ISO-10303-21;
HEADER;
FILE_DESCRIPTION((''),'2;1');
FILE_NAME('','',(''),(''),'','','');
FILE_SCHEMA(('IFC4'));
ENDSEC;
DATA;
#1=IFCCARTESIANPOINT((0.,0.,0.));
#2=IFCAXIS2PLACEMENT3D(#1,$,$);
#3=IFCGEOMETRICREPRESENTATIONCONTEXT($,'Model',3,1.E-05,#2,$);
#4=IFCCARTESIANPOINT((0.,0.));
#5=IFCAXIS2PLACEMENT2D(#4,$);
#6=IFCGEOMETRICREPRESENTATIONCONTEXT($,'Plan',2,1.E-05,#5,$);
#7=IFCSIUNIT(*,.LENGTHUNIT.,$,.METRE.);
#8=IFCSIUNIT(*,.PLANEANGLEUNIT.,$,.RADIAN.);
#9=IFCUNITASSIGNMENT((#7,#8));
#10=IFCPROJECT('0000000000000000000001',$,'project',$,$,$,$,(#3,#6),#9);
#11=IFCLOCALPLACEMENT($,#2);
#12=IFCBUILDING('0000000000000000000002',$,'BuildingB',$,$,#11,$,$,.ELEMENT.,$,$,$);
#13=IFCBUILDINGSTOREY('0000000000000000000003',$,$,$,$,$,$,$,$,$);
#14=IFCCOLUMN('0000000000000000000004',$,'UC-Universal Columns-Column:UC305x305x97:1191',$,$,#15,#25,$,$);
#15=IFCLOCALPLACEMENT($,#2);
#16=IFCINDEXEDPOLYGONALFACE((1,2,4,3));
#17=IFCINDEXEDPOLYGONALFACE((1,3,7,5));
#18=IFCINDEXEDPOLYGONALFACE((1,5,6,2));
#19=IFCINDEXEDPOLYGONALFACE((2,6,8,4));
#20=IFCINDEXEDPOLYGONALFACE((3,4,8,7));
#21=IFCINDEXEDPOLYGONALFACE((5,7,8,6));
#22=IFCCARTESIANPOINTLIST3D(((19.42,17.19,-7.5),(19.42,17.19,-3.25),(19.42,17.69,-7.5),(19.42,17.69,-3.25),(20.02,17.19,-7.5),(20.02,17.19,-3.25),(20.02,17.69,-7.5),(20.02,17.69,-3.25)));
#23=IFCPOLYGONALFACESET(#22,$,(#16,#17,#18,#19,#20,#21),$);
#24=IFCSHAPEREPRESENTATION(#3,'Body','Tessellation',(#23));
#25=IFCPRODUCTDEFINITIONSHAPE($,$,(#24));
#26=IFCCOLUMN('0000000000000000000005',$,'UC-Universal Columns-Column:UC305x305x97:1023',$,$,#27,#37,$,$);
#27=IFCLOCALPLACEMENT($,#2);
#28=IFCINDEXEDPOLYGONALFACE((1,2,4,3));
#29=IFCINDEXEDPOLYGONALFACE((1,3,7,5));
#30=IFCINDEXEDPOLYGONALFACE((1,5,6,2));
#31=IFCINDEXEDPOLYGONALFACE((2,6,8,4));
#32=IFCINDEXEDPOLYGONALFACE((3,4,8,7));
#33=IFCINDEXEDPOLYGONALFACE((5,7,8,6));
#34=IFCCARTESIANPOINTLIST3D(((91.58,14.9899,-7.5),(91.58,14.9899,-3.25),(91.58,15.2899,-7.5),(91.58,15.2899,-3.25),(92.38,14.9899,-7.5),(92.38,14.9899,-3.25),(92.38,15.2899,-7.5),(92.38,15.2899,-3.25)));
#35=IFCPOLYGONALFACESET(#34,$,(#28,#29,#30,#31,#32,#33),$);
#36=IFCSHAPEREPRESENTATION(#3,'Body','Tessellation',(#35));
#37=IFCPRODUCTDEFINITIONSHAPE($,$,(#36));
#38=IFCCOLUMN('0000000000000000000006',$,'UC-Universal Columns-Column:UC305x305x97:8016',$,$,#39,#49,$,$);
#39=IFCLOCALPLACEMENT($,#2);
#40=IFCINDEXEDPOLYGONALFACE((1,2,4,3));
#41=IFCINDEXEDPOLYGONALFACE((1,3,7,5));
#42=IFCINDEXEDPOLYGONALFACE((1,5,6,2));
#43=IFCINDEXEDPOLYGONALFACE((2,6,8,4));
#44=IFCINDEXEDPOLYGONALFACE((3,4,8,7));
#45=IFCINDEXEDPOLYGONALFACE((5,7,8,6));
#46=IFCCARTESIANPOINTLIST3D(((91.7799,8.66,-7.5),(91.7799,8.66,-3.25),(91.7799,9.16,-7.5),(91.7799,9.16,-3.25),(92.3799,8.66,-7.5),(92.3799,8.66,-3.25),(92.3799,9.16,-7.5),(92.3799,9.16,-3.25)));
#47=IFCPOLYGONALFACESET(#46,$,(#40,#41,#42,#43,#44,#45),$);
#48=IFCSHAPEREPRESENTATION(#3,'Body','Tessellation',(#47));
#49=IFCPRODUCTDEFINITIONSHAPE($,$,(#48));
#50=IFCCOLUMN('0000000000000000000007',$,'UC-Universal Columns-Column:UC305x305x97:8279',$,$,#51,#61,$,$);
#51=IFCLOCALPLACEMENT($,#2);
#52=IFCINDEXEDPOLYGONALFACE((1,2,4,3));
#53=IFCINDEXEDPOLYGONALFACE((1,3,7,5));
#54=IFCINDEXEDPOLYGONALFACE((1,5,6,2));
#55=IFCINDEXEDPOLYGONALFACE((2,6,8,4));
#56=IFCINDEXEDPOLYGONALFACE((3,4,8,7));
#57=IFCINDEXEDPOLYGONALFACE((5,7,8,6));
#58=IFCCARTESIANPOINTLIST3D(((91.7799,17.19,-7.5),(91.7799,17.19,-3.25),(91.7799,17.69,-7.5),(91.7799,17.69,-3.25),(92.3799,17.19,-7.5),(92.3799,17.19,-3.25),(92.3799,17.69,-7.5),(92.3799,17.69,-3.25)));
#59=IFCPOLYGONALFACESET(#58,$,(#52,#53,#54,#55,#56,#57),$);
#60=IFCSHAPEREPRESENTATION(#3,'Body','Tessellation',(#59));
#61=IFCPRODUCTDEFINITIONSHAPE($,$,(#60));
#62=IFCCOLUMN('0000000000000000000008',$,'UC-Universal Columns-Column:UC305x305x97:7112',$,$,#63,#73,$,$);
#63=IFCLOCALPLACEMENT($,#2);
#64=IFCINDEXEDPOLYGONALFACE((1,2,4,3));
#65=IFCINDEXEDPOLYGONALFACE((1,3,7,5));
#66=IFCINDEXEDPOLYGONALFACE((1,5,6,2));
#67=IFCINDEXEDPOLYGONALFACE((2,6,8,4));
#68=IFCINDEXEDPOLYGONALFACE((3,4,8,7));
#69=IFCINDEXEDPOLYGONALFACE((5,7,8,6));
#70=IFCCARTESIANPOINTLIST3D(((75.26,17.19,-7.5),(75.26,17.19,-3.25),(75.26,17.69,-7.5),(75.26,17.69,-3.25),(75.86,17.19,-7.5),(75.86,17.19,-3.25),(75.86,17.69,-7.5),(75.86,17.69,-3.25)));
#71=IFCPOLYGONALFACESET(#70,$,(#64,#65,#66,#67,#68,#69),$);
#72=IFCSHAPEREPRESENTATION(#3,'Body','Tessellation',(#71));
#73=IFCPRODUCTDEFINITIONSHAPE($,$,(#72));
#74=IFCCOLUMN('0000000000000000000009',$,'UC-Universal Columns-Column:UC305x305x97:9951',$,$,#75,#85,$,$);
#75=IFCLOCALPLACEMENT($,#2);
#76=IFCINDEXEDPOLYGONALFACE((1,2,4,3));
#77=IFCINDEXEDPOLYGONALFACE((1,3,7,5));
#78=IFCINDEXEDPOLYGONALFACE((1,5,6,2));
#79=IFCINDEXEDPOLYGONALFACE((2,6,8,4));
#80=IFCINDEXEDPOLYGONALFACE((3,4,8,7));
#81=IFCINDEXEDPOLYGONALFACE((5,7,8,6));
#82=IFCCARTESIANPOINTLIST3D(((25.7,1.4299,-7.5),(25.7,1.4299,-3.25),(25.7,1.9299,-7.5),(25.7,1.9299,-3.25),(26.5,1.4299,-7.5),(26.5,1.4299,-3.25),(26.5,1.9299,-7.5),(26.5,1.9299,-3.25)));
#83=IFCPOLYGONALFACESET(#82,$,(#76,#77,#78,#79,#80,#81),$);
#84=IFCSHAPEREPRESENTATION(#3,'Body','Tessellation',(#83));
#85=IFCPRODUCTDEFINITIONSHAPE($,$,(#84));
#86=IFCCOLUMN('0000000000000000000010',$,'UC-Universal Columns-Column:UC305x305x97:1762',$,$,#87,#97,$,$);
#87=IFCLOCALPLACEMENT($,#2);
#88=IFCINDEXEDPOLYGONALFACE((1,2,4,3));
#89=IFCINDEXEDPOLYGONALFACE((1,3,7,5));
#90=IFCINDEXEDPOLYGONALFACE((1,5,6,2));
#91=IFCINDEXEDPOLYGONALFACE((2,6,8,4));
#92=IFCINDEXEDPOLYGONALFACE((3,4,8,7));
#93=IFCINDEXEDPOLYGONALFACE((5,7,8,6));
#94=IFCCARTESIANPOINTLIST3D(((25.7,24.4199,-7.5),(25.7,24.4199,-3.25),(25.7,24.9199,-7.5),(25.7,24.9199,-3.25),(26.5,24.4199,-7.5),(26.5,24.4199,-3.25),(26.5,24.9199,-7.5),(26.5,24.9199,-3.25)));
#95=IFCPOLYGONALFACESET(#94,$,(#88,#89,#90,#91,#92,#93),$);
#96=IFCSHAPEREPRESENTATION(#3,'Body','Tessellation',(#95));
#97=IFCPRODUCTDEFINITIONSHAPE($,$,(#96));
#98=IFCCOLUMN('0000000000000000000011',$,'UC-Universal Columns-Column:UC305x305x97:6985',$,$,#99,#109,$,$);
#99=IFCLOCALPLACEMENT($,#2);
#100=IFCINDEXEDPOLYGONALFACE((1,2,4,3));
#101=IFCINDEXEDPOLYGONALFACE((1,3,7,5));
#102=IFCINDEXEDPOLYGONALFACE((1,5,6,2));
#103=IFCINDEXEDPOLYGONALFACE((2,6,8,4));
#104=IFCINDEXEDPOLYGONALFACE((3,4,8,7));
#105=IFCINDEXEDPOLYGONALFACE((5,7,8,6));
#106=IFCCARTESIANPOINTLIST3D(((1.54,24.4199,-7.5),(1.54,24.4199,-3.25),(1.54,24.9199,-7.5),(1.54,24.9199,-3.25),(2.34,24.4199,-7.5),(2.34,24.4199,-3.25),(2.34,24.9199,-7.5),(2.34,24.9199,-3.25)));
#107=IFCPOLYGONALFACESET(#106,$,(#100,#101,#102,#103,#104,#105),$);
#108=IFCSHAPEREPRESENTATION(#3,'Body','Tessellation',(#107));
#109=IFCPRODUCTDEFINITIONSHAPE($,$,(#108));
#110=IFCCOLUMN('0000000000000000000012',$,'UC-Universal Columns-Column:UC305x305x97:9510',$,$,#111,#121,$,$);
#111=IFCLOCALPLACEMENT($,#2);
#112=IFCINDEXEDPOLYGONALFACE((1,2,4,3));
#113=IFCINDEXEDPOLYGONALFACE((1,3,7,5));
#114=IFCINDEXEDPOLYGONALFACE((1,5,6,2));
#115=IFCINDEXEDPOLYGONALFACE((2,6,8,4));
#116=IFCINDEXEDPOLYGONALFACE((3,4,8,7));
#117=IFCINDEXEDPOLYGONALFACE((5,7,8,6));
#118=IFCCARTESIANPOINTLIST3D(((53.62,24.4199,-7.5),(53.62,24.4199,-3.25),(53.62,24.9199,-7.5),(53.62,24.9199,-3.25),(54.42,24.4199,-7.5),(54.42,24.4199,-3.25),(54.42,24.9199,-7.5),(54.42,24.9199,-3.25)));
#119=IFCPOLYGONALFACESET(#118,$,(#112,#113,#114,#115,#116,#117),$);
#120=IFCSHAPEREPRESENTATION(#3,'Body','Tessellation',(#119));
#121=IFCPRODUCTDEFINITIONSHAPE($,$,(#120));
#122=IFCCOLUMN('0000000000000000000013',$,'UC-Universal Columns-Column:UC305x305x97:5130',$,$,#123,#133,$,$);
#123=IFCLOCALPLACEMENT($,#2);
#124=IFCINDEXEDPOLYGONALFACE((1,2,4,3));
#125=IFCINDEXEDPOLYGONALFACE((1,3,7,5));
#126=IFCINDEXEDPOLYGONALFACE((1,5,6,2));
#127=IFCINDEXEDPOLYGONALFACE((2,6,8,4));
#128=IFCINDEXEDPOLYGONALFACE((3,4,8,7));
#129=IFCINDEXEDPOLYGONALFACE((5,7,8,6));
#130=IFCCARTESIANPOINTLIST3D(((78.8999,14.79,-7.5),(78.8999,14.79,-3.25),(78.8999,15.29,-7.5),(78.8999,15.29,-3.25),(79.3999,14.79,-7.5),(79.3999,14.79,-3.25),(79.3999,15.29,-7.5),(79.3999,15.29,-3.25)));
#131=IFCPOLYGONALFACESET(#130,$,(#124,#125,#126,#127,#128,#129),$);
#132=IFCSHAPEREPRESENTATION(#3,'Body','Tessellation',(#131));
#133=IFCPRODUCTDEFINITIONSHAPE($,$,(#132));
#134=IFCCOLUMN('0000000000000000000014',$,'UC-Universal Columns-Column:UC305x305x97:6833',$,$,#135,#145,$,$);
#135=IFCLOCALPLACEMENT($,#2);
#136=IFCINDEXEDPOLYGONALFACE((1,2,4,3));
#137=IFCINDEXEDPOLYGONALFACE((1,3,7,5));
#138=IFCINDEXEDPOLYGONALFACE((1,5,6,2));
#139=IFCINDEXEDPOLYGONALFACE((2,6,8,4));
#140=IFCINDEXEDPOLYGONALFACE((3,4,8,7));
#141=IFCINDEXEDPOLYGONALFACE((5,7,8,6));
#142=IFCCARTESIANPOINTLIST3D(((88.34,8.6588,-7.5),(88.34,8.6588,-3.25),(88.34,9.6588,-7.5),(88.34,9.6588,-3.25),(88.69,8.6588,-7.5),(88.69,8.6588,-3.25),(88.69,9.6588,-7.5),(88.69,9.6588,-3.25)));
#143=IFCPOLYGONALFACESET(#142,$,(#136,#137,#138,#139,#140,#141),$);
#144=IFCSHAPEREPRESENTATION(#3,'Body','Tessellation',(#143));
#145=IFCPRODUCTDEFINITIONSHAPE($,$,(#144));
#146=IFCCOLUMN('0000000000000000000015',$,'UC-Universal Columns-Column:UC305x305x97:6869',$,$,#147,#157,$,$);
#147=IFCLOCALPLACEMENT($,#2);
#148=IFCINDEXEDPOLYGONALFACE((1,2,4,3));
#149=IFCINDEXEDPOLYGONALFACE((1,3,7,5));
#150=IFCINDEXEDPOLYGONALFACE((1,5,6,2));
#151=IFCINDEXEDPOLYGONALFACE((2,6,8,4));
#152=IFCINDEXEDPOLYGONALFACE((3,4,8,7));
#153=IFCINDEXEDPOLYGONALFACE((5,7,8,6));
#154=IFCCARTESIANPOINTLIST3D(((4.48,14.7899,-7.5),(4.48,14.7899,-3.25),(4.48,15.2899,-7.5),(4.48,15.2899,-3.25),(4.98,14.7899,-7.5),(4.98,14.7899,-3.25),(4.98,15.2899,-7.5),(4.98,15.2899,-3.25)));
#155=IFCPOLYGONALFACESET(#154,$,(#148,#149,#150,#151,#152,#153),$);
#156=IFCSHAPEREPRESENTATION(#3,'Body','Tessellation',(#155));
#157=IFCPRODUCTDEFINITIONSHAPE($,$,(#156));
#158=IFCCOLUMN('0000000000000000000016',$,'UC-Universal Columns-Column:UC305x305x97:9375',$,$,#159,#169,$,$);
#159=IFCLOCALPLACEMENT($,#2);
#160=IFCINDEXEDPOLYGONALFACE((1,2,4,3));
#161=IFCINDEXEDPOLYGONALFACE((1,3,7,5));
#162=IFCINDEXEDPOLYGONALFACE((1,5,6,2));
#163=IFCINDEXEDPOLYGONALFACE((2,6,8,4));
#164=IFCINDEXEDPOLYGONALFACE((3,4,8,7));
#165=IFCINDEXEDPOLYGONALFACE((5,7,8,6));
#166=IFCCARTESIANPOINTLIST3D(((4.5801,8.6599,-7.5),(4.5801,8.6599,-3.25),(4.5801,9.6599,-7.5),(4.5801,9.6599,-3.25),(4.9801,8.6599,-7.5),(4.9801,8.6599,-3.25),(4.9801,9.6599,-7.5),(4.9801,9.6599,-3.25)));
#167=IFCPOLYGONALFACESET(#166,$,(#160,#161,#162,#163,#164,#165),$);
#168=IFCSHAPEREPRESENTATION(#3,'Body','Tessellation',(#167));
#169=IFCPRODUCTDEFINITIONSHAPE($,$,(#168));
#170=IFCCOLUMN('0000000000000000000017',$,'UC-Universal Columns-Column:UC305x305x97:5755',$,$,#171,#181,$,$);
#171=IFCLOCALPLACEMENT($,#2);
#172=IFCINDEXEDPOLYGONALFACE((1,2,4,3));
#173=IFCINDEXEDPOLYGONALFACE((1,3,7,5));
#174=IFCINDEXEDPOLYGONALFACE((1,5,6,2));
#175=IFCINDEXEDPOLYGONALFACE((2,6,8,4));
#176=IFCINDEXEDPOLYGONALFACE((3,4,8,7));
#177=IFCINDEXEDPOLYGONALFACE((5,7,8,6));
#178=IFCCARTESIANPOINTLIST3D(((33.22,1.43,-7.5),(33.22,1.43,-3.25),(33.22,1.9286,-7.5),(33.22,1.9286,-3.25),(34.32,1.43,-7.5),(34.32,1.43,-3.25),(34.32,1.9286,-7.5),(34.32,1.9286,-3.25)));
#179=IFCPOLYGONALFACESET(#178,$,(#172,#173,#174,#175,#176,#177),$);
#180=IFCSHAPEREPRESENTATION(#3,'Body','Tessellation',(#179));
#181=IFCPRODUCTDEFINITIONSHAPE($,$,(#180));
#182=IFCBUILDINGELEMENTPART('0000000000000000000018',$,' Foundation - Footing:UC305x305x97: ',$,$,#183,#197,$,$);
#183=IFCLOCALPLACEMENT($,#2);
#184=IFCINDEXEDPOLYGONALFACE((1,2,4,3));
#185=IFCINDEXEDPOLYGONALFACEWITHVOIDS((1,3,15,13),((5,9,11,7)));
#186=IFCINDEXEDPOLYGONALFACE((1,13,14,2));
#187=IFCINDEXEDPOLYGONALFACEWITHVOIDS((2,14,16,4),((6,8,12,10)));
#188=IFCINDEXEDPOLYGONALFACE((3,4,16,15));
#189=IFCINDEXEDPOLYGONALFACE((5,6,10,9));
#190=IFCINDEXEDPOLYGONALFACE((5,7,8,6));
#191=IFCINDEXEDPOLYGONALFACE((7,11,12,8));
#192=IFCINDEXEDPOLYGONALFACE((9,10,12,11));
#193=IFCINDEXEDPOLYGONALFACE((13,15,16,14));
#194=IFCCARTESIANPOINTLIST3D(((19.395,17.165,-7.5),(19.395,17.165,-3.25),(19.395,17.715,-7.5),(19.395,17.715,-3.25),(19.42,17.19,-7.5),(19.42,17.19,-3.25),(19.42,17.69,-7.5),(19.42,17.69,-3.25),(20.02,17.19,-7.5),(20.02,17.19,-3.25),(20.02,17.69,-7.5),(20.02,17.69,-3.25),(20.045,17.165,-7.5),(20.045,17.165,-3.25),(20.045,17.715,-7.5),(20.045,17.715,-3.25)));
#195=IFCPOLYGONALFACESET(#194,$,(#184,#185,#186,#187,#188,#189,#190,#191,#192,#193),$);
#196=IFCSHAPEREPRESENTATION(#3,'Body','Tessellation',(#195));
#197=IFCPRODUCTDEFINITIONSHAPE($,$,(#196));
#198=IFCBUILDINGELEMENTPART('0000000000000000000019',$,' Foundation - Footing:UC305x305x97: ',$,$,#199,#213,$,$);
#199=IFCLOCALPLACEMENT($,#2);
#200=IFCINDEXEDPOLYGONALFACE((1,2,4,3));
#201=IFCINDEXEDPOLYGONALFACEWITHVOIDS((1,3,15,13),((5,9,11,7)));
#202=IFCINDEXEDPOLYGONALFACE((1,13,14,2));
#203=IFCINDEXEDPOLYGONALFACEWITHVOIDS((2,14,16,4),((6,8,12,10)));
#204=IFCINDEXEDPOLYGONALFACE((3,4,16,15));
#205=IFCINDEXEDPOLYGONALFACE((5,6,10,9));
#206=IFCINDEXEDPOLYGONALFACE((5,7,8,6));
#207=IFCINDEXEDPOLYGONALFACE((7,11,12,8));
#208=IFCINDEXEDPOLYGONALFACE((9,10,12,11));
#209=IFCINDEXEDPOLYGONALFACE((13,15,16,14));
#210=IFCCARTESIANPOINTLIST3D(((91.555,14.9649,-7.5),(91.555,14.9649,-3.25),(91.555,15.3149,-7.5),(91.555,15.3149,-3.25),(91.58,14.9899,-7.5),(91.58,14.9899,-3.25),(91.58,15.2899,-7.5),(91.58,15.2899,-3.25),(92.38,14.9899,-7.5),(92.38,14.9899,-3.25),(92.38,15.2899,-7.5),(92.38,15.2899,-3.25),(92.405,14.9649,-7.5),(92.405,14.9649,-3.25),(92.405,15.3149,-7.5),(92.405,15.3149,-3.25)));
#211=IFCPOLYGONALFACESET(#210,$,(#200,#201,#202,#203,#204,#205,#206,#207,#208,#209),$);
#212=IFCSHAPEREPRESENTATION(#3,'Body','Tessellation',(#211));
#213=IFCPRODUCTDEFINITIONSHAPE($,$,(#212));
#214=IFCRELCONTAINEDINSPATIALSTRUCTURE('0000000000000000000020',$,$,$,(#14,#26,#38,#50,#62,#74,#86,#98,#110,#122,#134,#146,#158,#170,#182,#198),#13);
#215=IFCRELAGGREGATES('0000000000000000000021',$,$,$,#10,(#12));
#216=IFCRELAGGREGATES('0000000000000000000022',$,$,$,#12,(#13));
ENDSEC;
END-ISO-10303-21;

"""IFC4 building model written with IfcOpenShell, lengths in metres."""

from ifc_helpers import new_model, si_unit, origin, origin_2d, place, context, project, spatial, polyline, outline, extrude, element, save


model = new_model("IFC4")

# Units and contexts
model_context = context("Model", 3, precision=1e-05, world=origin())
plan_context = context("Plan", 2, precision=1e-05, world=origin_2d())
ifc_project = project(units=[si_unit("LENGTHUNIT", "METRE"), si_unit("PLANEANGLEUNIT", "RADIAN")], contexts=[model_context, plan_context])

# Building, storey
building_placement = place(None, origin())
building = spatial("IfcBuilding", under=ifc_project, at=building_placement, Name="BuildingB", CompositionType="ELEMENT")
storey = spatial("IfcBuildingStorey", under=building)

# Columns
element("IfcColumn", 1, inside=storey, Name="UC-Universal Columns-Column:UC305x305x97:1191", context=model_context, shape_type="SweptSolid", body=[
    extrude(outline(polyline([(19.42, 17.69, -7.5), (20.02, 17.69, -7.5), (20.02, 17.19, -7.5), (19.42, 17.19, -7.5), (19.42, 17.69, -7.5)])), None, (0.0, 0.0, 1.0), 4.25),
])
element("IfcColumn", 2, inside=storey, Name="UC-Universal Columns-Column:UC305x305x97:1023", context=model_context, shape_type="SweptSolid", body=[
    extrude(outline(polyline([(92.38, 15.2899, -7.5), (91.58, 15.2899, -7.5), (91.58, 14.9899, -7.5), (92.38, 14.9899, -7.5), (92.38, 15.2899, -7.5)])), None, (0.0, 0.0, 1.0), 4.25),
])
element("IfcColumn", 3, inside=storey, Name="UC-Universal Columns-Column:UC305x305x97:8016", context=model_context, shape_type="SweptSolid", body=[
    extrude(outline(polyline([(92.3799, 8.66, -7.5), (91.7799, 8.66, -7.5), (91.7799, 9.16, -7.5), (92.3799, 9.16, -7.5), (92.3799, 8.66, -7.5)])), None, (0.0, 0.0, 1.0), 4.25),
])
element("IfcColumn", 4, inside=storey, Name="UC-Universal Columns-Column:UC305x305x97:8279", context=model_context, shape_type="SweptSolid", body=[
    extrude(outline(polyline([(92.3799, 17.69, -7.5), (91.7799, 17.69, -7.5), (91.7799, 17.19, -7.5), (92.3799, 17.19, -7.5), (92.3799, 17.69, -7.5)])), None, (0.0, 0.0, 1.0), 4.25),
])
element("IfcColumn", 5, inside=storey, Name="UC-Universal Columns-Column:UC305x305x97:7112", context=model_context, shape_type="SweptSolid", body=[
    extrude(outline(polyline([(75.26, 17.69, -7.5), (75.86, 17.69, -7.5), (75.86, 17.19, -7.5), (75.26, 17.19, -7.5), (75.26, 17.69, -7.5)])), None, (0.0, 0.0, 1.0), 4.25),
])
element("IfcColumn", 6, inside=storey, Name="UC-Universal Columns-Column:UC305x305x97:9951", context=model_context, shape_type="SweptSolid", body=[
    extrude(outline(polyline([(25.7, 1.4299, -7.5), (26.5, 1.4299, -7.5), (26.5, 1.9299, -7.5), (25.7, 1.9299, -7.5), (25.7, 1.4299, -7.5)])), None, (0.0, 0.0, 1.0), 4.25),
])
element("IfcColumn", 7, inside=storey, Name="UC-Universal Columns-Column:UC305x305x97:1762", context=model_context, shape_type="SweptSolid", body=[
    extrude(outline(polyline([(25.7, 24.4199, -7.5), (26.5, 24.4199, -7.5), (26.5, 24.9199, -7.5), (25.7, 24.9199, -7.5), (25.7, 24.4199, -7.5)])), None, (0.0, 0.0, 1.0), 4.25),
])
element("IfcColumn", 8, inside=storey, Name="UC-Universal Columns-Column:UC305x305x97:6985", context=model_context, shape_type="SweptSolid", body=[
    extrude(outline(polyline([(1.54, 24.4199, -7.5), (2.34, 24.4199, -7.5), (2.34, 24.9199, -7.5), (1.54, 24.9199, -7.5), (1.54, 24.4199, -7.5)])), None, (0.0, 0.0, 1.0), 4.25),
])
element("IfcColumn", 9, inside=storey, Name="UC-Universal Columns-Column:UC305x305x97:9510", context=model_context, shape_type="SweptSolid", body=[
    extrude(outline(polyline([(54.42, 24.4199, -7.5), (53.62, 24.4199, -7.5), (53.62, 24.9199, -7.5), (54.42, 24.9199, -7.5), (54.42, 24.4199, -7.5)])), None, (0.0, 0.0, 1.0), 4.25),
])
element("IfcColumn", 10, inside=storey, Name="UC-Universal Columns-Column:UC305x305x97:5130", context=model_context, shape_type="SweptSolid", body=[
    extrude(outline(polyline([(78.8999, 15.29, -7.5), (79.3999, 15.29, -7.5), (79.3999, 14.79, -7.5), (78.8999, 14.79, -7.5), (78.8999, 15.29, -7.5)])), None, (0.0, 0.0, 1.0), 4.25),
])
element("IfcColumn", 11, inside=storey, Name="UC-Universal Columns-Column:UC305x305x97:6833", context=model_context, shape_type="SweptSolid", body=[
    extrude(outline(polyline([(88.34, 8.6588, -7.5), (88.69, 8.6588, -7.5), (88.69, 9.6588, -7.5), (88.34, 9.6588, -7.5), (88.34, 8.6588, -7.5)])), None, (0.0, 0.0, 1.0), 4.25),
])
element("IfcColumn", 12, inside=storey, Name="UC-Universal Columns-Column:UC305x305x97:6869", context=model_context, shape_type="SweptSolid", body=[
    extrude(outline(polyline([(4.98, 15.2899, -7.5), (4.48, 15.2899, -7.5), (4.48, 14.7899, -7.5), (4.98, 14.7899, -7.5), (4.98, 15.2899, -7.5)])), None, (0.0, 0.0, 1.0), 4.25),
])
element("IfcColumn", 13, inside=storey, Name="UC-Universal Columns-Column:UC305x305x97:9375", context=model_context, shape_type="SweptSolid", body=[
    extrude(outline(polyline([(4.5801, 8.6599, -7.5), (4.9801, 8.6599, -7.5), (4.9801, 9.6599, -7.5), (4.5801, 9.6599, -7.5), (4.5801, 8.6599, -7.5)])), None, (0.0, 0.0, 1.0), 4.25),
])
element("IfcColumn", 14, inside=storey, Name="UC-Universal Columns-Column:UC305x305x97:5755", context=model_context, shape_type="SweptSolid", body=[
    extrude(outline(polyline([(34.32, 1.43, -7.5), (33.22, 1.43, -7.5), (33.22, 1.9286, -7.5), (34.32, 1.9286, -7.5), (34.32, 1.43, -7.5)])), None, (0.0, 0.0, 1.0), 4.25),
])

# Building element parts, openings
building_element_part_1 = element("IfcBuildingElementPart", 15, inside=storey, Name=" Foundation - Footing:UC305x305x97: ", context=model_context, shape_type="SweptSolid", body=[
    extrude(outline(polyline([(19.395, 17.715, -7.5), (20.045, 17.715, -7.5), (20.045, 17.165, -7.5), (19.395, 17.165, -7.5), (19.395, 17.715, -7.5)])), None, (0.0, 0.0, 1.0), 4.25),
])
element("IfcOpeningElement", 16, inside=storey, cuts=building_element_part_1, context=model_context, shape_type="SweptSolid", body=[
    extrude(outline(polyline([(19.42, 17.69, -7.5), (20.02, 17.69, -7.5), (20.02, 17.19, -7.5), (19.42, 17.19, -7.5), (19.42, 17.69, -7.5)])), None, (0.0, 0.0, 1.0), 4.25),
])
building_element_part_2 = element("IfcBuildingElementPart", 17, inside=storey, Name=" Foundation - Footing:UC305x305x97: ", context=model_context, shape_type="SweptSolid", body=[
    extrude(outline(polyline([(92.405, 15.3149, -7.5), (91.555, 15.3149, -7.5), (91.555, 14.9649, -7.5), (92.405, 14.9649, -7.5), (92.405, 15.3149, -7.5)])), None, (0.0, 0.0, 1.0), 4.25),
])
element("IfcOpeningElement", 18, inside=storey, cuts=building_element_part_2, context=model_context, shape_type="SweptSolid", body=[
    extrude(outline(polyline([(92.38, 15.2899, -7.5), (91.58, 15.2899, -7.5), (91.58, 14.9899, -7.5), (92.38, 14.9899, -7.5), (92.38, 15.2899, -7.5)])), None, (0.0, 0.0, 1.0), 4.25),
])

save(model, "model.ifc")
